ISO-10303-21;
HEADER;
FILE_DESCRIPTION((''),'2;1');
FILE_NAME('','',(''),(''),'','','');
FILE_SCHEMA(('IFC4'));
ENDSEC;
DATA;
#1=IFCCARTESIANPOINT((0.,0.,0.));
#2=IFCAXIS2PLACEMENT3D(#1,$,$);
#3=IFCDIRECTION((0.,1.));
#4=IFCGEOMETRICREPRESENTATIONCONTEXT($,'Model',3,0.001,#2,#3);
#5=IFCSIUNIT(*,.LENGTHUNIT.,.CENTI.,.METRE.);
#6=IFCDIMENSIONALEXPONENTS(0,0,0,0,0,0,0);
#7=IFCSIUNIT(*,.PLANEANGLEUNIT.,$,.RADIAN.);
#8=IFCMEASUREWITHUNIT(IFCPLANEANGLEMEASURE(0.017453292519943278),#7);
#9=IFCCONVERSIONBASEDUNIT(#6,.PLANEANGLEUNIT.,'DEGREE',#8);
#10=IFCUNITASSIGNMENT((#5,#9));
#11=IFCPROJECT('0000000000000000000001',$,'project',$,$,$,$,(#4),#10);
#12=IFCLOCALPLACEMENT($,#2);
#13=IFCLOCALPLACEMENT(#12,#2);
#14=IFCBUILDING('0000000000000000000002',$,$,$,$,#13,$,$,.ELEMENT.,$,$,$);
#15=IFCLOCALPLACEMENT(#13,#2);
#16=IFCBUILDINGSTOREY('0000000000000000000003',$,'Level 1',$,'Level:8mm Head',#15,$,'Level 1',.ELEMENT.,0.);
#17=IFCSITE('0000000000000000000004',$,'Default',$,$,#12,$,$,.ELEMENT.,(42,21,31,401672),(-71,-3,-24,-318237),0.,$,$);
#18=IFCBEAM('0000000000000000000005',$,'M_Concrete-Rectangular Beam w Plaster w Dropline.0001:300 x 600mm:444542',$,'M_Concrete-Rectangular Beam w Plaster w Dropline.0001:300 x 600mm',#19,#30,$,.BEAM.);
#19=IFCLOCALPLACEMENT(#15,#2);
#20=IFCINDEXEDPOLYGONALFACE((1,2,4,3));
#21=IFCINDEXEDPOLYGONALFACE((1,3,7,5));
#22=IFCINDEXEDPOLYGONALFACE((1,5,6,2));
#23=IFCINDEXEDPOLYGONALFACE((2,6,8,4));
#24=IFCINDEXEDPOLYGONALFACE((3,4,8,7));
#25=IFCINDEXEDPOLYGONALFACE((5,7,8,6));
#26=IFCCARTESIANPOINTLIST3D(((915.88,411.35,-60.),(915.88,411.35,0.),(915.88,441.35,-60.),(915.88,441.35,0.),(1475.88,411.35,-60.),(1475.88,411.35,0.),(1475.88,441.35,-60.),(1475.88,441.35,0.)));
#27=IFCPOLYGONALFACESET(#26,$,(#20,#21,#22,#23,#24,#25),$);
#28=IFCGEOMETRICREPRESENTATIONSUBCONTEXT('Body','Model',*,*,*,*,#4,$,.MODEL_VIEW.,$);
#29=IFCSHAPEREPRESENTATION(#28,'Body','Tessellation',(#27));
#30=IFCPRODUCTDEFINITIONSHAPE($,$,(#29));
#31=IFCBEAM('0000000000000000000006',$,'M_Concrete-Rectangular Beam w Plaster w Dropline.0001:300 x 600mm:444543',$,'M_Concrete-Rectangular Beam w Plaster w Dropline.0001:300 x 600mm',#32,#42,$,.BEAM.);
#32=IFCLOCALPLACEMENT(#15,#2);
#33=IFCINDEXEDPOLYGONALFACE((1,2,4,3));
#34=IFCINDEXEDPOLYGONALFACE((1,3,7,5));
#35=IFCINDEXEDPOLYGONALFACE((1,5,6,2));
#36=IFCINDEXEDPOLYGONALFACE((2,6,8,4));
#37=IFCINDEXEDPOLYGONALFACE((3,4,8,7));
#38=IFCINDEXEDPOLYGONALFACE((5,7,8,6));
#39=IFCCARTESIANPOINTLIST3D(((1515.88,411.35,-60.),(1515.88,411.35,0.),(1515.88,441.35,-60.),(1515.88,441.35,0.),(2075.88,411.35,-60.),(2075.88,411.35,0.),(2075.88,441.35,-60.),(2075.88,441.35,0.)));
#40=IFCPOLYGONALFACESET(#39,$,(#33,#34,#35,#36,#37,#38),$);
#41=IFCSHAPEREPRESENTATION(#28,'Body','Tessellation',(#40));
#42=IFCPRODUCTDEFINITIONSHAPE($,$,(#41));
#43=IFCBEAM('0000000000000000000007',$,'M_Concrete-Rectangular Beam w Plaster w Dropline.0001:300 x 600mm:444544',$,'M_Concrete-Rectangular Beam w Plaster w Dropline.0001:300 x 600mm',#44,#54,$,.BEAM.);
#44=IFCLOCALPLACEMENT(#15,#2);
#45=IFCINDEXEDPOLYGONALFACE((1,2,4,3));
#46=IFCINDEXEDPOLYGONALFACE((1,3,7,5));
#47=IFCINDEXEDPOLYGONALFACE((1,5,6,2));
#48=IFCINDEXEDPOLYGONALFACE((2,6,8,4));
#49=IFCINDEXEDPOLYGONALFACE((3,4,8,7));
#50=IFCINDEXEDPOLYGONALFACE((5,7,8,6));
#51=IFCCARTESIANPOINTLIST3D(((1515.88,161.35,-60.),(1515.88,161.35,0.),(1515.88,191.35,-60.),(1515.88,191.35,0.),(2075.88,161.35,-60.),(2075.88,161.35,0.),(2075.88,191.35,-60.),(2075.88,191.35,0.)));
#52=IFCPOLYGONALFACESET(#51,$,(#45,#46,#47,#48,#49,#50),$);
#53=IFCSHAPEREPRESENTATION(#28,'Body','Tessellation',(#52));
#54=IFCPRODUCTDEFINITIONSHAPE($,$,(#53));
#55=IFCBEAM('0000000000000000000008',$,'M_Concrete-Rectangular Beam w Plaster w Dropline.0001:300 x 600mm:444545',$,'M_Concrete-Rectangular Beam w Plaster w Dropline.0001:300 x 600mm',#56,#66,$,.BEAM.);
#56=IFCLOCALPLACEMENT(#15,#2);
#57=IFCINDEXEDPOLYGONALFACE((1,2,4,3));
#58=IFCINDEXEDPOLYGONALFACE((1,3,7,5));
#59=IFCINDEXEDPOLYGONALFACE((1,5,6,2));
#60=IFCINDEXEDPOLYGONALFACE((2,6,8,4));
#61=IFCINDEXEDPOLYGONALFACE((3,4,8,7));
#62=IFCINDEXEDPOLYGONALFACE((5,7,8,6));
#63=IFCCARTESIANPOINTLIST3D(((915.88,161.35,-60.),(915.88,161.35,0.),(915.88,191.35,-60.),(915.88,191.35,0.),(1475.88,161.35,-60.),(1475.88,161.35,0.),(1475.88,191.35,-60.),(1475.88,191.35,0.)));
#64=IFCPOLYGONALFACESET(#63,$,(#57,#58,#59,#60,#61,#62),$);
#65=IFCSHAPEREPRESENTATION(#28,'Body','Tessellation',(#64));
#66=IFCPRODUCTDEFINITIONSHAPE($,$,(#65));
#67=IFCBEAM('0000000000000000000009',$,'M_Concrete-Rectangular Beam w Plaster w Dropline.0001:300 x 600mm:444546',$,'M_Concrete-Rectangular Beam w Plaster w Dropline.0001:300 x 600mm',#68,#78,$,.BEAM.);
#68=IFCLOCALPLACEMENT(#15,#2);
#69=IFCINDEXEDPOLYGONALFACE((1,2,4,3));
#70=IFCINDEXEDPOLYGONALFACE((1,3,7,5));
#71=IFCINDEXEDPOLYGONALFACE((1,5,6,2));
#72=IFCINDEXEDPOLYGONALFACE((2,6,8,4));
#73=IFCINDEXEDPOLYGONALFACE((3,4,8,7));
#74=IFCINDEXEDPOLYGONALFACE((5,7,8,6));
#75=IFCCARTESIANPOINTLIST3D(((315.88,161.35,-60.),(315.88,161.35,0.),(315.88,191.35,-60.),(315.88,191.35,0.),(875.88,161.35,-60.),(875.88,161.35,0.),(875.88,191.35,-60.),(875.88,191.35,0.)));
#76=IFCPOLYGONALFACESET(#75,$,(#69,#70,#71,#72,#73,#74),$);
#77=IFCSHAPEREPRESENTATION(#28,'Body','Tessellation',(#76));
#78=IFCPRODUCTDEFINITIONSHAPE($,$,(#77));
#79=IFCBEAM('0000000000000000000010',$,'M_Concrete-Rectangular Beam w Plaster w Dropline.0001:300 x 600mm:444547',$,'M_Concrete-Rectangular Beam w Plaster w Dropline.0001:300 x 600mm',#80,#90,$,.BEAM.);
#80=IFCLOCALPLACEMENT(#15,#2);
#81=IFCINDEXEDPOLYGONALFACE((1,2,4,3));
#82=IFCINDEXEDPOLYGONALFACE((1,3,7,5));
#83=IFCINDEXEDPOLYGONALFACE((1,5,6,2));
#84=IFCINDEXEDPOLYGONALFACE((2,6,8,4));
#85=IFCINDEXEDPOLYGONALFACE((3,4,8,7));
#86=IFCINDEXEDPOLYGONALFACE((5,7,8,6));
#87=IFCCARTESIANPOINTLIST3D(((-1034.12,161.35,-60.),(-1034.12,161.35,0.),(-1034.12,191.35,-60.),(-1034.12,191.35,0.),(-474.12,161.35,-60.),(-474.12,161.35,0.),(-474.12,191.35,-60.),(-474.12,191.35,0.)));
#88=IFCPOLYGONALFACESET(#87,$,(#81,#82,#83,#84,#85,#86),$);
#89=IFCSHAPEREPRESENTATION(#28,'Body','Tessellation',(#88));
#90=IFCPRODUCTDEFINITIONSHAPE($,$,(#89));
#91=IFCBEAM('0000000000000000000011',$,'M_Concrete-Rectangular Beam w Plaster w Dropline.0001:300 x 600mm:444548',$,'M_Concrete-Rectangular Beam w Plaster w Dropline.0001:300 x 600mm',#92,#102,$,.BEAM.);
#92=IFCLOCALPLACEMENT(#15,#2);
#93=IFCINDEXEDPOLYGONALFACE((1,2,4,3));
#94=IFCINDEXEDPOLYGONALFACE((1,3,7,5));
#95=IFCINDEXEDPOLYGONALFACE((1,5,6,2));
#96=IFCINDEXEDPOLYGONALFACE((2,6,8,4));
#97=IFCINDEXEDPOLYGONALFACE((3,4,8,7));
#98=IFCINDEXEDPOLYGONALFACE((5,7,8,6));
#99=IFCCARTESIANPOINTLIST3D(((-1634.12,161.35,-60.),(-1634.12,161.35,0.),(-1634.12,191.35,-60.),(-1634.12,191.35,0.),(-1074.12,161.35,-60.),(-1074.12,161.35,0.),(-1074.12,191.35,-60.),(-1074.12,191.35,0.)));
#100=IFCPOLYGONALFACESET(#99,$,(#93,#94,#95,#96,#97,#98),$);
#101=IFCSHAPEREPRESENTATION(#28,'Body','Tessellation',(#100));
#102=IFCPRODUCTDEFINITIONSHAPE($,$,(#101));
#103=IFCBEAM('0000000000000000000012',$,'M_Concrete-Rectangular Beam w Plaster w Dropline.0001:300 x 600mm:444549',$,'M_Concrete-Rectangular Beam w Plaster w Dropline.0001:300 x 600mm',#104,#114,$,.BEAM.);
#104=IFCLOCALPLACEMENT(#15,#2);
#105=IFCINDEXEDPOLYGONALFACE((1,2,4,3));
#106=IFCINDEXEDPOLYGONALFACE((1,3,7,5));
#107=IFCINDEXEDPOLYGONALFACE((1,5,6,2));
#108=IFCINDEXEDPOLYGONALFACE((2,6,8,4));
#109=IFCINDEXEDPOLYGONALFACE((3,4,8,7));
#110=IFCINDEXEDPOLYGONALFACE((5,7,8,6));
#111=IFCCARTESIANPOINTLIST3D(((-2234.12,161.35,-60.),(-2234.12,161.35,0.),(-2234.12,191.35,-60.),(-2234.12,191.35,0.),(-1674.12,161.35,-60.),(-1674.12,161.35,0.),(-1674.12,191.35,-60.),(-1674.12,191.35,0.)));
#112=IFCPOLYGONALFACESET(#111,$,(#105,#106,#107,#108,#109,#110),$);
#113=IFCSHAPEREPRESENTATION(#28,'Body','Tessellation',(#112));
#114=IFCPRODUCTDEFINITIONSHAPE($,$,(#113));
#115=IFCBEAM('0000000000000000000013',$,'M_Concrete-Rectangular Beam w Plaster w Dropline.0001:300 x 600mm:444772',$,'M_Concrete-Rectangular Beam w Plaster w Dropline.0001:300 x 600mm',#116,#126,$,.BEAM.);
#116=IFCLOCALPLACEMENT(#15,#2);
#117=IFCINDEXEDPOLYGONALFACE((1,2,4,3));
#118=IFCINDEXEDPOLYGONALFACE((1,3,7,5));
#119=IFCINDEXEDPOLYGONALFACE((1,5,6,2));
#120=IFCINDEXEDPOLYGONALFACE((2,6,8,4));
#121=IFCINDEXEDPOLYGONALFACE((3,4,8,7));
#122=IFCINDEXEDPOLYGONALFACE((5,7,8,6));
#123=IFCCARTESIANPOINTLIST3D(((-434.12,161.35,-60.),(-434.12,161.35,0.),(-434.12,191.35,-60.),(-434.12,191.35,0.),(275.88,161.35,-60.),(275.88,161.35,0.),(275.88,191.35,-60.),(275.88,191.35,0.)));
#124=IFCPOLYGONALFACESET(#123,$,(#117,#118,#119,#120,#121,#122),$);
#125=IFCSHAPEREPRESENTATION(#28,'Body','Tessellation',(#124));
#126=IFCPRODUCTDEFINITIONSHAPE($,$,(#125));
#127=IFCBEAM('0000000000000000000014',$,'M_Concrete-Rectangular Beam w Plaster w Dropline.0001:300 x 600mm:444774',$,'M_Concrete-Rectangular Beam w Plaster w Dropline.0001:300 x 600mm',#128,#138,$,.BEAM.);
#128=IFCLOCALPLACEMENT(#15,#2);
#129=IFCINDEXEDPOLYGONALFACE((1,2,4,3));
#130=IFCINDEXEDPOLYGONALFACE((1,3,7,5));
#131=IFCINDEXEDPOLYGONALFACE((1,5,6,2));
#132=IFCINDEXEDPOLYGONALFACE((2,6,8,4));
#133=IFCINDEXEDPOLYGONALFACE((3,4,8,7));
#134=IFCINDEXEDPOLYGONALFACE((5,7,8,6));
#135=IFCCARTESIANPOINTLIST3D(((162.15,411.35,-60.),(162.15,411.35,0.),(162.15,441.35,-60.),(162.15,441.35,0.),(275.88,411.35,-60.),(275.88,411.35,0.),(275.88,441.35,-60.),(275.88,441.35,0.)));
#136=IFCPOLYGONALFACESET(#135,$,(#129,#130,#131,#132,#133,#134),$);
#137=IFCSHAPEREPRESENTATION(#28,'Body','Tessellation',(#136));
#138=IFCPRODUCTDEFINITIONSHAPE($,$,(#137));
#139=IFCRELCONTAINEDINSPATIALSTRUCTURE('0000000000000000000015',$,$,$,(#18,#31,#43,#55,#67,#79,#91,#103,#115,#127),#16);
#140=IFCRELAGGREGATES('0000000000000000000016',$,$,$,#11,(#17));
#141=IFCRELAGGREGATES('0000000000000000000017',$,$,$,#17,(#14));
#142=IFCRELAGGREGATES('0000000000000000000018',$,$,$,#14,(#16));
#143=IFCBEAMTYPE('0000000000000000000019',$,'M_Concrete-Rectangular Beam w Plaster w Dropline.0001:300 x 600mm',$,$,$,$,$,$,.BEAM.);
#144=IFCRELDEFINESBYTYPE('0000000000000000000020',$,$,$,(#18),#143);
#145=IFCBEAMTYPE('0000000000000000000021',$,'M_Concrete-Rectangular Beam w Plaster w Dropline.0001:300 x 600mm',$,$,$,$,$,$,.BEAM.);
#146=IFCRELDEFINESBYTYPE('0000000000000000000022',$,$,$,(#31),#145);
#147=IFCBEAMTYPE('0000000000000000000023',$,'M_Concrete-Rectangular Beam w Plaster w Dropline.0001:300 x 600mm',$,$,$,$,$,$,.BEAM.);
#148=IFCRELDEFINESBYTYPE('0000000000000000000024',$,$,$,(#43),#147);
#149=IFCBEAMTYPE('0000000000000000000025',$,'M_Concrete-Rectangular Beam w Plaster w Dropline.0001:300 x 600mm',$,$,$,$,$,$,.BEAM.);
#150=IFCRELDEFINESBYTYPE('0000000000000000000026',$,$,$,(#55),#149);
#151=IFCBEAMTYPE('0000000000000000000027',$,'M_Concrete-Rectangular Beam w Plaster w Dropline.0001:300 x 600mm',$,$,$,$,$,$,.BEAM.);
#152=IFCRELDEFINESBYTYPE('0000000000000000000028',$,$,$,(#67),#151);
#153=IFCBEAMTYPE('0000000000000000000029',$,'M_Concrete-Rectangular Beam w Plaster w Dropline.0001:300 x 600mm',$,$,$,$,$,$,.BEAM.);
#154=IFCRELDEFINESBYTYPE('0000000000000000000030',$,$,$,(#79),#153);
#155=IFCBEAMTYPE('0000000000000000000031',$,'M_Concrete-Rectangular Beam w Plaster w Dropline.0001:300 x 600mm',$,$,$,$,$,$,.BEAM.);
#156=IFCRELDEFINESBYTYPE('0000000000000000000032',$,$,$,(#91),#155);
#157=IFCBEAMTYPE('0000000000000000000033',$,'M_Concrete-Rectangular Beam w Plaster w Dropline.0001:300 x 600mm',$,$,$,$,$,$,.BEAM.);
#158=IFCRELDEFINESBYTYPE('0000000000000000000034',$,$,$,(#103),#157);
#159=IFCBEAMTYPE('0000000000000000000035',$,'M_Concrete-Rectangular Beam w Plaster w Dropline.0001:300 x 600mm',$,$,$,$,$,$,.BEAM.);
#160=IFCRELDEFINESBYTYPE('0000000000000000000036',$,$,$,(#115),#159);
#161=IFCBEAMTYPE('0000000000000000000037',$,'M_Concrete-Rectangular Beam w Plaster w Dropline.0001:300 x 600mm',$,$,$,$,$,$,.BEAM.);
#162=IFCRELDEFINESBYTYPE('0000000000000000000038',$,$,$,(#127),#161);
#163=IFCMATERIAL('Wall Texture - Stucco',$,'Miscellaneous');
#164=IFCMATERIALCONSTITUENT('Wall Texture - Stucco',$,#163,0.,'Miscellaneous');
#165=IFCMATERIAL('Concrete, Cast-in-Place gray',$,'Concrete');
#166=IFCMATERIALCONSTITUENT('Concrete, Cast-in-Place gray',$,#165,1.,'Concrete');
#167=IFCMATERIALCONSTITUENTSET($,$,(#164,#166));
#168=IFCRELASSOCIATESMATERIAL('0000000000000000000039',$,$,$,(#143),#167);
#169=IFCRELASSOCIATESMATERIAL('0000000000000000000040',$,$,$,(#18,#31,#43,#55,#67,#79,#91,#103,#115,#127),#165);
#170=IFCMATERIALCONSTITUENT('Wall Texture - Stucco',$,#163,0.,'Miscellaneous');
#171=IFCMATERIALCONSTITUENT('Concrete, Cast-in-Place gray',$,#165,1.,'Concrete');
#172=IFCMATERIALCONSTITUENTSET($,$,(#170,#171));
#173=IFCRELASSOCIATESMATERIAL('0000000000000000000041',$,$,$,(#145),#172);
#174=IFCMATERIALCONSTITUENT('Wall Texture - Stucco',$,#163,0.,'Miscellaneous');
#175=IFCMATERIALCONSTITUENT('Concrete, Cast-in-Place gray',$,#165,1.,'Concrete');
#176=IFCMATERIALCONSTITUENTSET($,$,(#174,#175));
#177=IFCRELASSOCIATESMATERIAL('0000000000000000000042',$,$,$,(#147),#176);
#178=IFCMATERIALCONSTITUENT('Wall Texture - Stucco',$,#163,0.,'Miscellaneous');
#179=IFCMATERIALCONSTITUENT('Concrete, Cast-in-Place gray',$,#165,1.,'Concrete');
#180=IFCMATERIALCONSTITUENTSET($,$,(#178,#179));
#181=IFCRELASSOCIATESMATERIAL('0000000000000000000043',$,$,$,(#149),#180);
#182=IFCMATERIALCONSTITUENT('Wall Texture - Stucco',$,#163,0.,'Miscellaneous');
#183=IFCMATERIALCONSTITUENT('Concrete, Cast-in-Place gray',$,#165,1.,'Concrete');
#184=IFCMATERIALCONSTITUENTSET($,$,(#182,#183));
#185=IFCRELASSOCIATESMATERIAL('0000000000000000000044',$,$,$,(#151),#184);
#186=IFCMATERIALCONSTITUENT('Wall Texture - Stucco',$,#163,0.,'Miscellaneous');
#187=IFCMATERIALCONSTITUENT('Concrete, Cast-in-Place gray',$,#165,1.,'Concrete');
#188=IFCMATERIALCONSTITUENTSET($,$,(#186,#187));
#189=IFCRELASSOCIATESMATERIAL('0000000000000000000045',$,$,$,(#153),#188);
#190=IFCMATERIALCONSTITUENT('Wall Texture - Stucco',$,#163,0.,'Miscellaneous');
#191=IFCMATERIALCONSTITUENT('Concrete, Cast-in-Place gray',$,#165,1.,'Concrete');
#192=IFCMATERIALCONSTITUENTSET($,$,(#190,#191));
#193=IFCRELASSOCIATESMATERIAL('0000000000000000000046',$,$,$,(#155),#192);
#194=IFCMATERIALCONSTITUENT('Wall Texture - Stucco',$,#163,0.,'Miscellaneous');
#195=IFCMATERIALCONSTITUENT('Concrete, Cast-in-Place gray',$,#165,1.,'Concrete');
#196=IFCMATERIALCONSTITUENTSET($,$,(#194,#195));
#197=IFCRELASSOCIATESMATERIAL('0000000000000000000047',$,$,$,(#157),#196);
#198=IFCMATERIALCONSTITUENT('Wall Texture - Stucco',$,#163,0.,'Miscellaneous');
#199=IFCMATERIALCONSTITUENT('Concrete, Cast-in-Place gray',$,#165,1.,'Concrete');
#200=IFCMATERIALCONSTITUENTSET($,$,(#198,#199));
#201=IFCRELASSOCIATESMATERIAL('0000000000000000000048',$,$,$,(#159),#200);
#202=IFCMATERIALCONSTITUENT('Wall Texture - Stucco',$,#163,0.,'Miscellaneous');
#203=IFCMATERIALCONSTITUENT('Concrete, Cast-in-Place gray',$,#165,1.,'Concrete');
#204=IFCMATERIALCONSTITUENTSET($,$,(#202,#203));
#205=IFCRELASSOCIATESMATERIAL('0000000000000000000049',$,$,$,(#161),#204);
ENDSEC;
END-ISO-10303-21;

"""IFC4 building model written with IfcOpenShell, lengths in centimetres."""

from ifc_helpers import new_model, entity, si_unit, converted_unit, direction, frame, origin, place, context, subcontext, project, spatial, indexed_curve, outline, extrude, source, transform, mapped, material, constituent, constituent_set, type_object, type_shapes, element, save


model = new_model("IFC4")

# Units and contexts
model_context = context("Model", 3, precision=0.001, world=origin(), true_north=direction((0.0, 1.0)))
body_context = subcontext(model_context, "Body", "Model", "MODEL_VIEW")
ifc_project = project(units=[si_unit("LENGTHUNIT", "METRE", prefix="CENTI"), converted_unit("PLANEANGLEUNIT", "DEGREE", entity("IfcPlaneAngleMeasure", 0.017453292519943278), si_unit("PLANEANGLEUNIT", "RADIAN"), dimensions=[0, 0, 0, 0, 0, 0, 0])], contexts=[model_context])

# Site, building, storey
site_placement = place(None, origin())
site = spatial("IfcSite", under=ifc_project, at=site_placement, Name="Default", CompositionType="ELEMENT", RefLatitude=(42, 21, 31, 401672), RefLongitude=(-71, -3, -24, -318237), RefElevation=0.0)
building_placement = place(site_placement, origin())
building = spatial("IfcBuilding", under=site, at=building_placement, CompositionType="ELEMENT")
storey_placement = place(building_placement, origin())
storey = spatial("IfcBuildingStorey", under=building, at=storey_placement, Name="Level 1", ObjectType="Level:8mm Head", LongName="Level 1", CompositionType="ELEMENT", Elevation=0.0)

# Beams
ifc_material_1 = material(Name="Concrete, Cast-in-Place gray", Category="Concrete")
ifc_material_2 = material(Name="Wall Texture - Stucco", Category="Miscellaneous")
ifc_constituent_1 = constituent(ifc_material_2, Name="Wall Texture - Stucco", Category="Miscellaneous", fraction=0.0)
ifc_constituent_2 = constituent(ifc_material_1, Name="Concrete, Cast-in-Place gray", Category="Concrete", fraction=1.0)
ifc_constituent_set_1 = constituent_set(constituents=[ifc_constituent_1, ifc_constituent_2])
beam_type_1 = type_object("IfcBeamType", Name="M_Concrete-Rectangular Beam w Plaster w Dropline.0001:300 x 600mm", PredefinedType="BEAM", material=ifc_constituent_set_1)
shared_shape_1 = source(origin(), body_context, "Body", "SweptSolid", [
    extrude(outline(indexed_curve([(-30.0, -15.0), (30.0, -15.0), (30.0, 15.0), (-30.0, 15.0), (-30.0, -15.0)], self_intersect=False)), frame((915.88, 426.35, -30.0), z_axis=(1.0, 0.0, 0.0), x_axis=(0.0, 0.0, -1.0)), (0.0, 0.0, 1.0), 560.0),
])
type_shapes(beam_type_1, [shared_shape_1])
beam_1_placement = place(storey_placement, origin())
element("IfcBeam", 1, at=beam_1_placement, inside=storey, type_object=beam_type_1, material=ifc_material_1, Name="M_Concrete-Rectangular Beam w Plaster w Dropline.0001:300 x 600mm:444542", ObjectType="M_Concrete-Rectangular Beam w Plaster w Dropline.0001:300 x 600mm", PredefinedType="BEAM", context=body_context, shape_type="MappedRepresentation", body=[
    mapped(shared_shape_1, transform((0.0, 0.0, 0.0), scale=1.0)),
])
ifc_constituent_3 = constituent(ifc_material_2, Name="Wall Texture - Stucco", Category="Miscellaneous", fraction=0.0)
ifc_constituent_4 = constituent(ifc_material_1, Name="Concrete, Cast-in-Place gray", Category="Concrete", fraction=1.0)
ifc_constituent_set_2 = constituent_set(constituents=[ifc_constituent_3, ifc_constituent_4])
beam_type_2 = type_object("IfcBeamType", Name="M_Concrete-Rectangular Beam w Plaster w Dropline.0001:300 x 600mm", PredefinedType="BEAM", material=ifc_constituent_set_2)
shared_shape_2 = source(origin(), body_context, "Body", "SweptSolid", [
    extrude(outline(indexed_curve([(-30.0, -15.0), (30.0, -15.0), (30.0, 15.0), (-30.0, 15.0), (-30.0, -15.0)], self_intersect=False)), frame((1515.88, 426.35, -30.0), z_axis=(1.0, 0.0, 0.0), x_axis=(0.0, 0.0, -1.0)), (0.0, 0.0, 1.0), 560.0),
])
type_shapes(beam_type_2, [shared_shape_2])
beam_2_placement = place(storey_placement, origin())
element("IfcBeam", 2, at=beam_2_placement, inside=storey, type_object=beam_type_2, material=ifc_material_1, Name="M_Concrete-Rectangular Beam w Plaster w Dropline.0001:300 x 600mm:444543", ObjectType="M_Concrete-Rectangular Beam w Plaster w Dropline.0001:300 x 600mm", PredefinedType="BEAM", context=body_context, shape_type="MappedRepresentation", body=[
    mapped(shared_shape_2, transform((0.0, 0.0, 0.0), scale=1.0)),
])
ifc_constituent_5 = constituent(ifc_material_2, Name="Wall Texture - Stucco", Category="Miscellaneous", fraction=0.0)
ifc_constituent_6 = constituent(ifc_material_1, Name="Concrete, Cast-in-Place gray", Category="Concrete", fraction=1.0)
ifc_constituent_set_3 = constituent_set(constituents=[ifc_constituent_5, ifc_constituent_6])
beam_type_3 = type_object("IfcBeamType", Name="M_Concrete-Rectangular Beam w Plaster w Dropline.0001:300 x 600mm", PredefinedType="BEAM", material=ifc_constituent_set_3)
shared_shape_3 = source(origin(), body_context, "Body", "SweptSolid", [
    extrude(outline(indexed_curve([(-30.0, -15.0), (30.0, -15.0), (30.0, 15.0), (-30.0, 15.0), (-30.0, -15.0)], self_intersect=False)), frame((2075.88, 176.35, -30.0), z_axis=(-1.0, 0.0, 0.0), x_axis=(0.0, 0.0, -1.0)), (0.0, 0.0, 1.0), 560.0),
])
type_shapes(beam_type_3, [shared_shape_3])
beam_3_placement = place(storey_placement, origin())
element("IfcBeam", 3, at=beam_3_placement, inside=storey, type_object=beam_type_3, material=ifc_material_1, Name="M_Concrete-Rectangular Beam w Plaster w Dropline.0001:300 x 600mm:444544", ObjectType="M_Concrete-Rectangular Beam w Plaster w Dropline.0001:300 x 600mm", PredefinedType="BEAM", context=body_context, shape_type="MappedRepresentation", body=[
    mapped(shared_shape_3, transform((0.0, 0.0, 0.0), scale=1.0)),
])
ifc_constituent_7 = constituent(ifc_material_2, Name="Wall Texture - Stucco", Category="Miscellaneous", fraction=0.0)
ifc_constituent_8 = constituent(ifc_material_1, Name="Concrete, Cast-in-Place gray", Category="Concrete", fraction=1.0)
ifc_constituent_set_4 = constituent_set(constituents=[ifc_constituent_7, ifc_constituent_8])
beam_type_4 = type_object("IfcBeamType", Name="M_Concrete-Rectangular Beam w Plaster w Dropline.0001:300 x 600mm", PredefinedType="BEAM", material=ifc_constituent_set_4)
shared_shape_4 = source(origin(), body_context, "Body", "SweptSolid", [
    extrude(outline(indexed_curve([(-30.0, -15.0), (30.0, -15.0), (30.0, 15.0), (-30.0, 15.0), (-30.0, -15.0)], self_intersect=False)), frame((1475.88, 176.35, -30.0), z_axis=(-1.0, 0.0, 0.0), x_axis=(0.0, 0.0, -1.0)), (0.0, 0.0, 1.0), 560.0),
])
type_shapes(beam_type_4, [shared_shape_4])
beam_4_placement = place(storey_placement, origin())
element("IfcBeam", 4, at=beam_4_placement, inside=storey, type_object=beam_type_4, material=ifc_material_1, Name="M_Concrete-Rectangular Beam w Plaster w Dropline.0001:300 x 600mm:444545", ObjectType="M_Concrete-Rectangular Beam w Plaster w Dropline.0001:300 x 600mm", PredefinedType="BEAM", context=body_context, shape_type="MappedRepresentation", body=[
    mapped(shared_shape_4, transform((0.0, 0.0, 0.0), scale=1.0)),
])
ifc_constituent_9 = constituent(ifc_material_2, Name="Wall Texture - Stucco", Category="Miscellaneous", fraction=0.0)
ifc_constituent_10 = constituent(ifc_material_1, Name="Concrete, Cast-in-Place gray", Category="Concrete", fraction=1.0)
ifc_constituent_set_5 = constituent_set(constituents=[ifc_constituent_9, ifc_constituent_10])
beam_type_5 = type_object("IfcBeamType", Name="M_Concrete-Rectangular Beam w Plaster w Dropline.0001:300 x 600mm", PredefinedType="BEAM", material=ifc_constituent_set_5)
shared_shape_5 = source(origin(), body_context, "Body", "SweptSolid", [
    extrude(outline(indexed_curve([(-30.0, -15.0), (30.0, -15.0), (30.0, 15.0), (-30.0, 15.0), (-30.0, -15.0)], self_intersect=False)), frame((875.88, 176.35, -30.0), z_axis=(-1.0, 0.0, 0.0), x_axis=(0.0, 0.0, -1.0)), (0.0, 0.0, 1.0), 560.0),
])
type_shapes(beam_type_5, [shared_shape_5])
beam_5_placement = place(storey_placement, origin())
element("IfcBeam", 5, at=beam_5_placement, inside=storey, type_object=beam_type_5, material=ifc_material_1, Name="M_Concrete-Rectangular Beam w Plaster w Dropline.0001:300 x 600mm:444546", ObjectType="M_Concrete-Rectangular Beam w Plaster w Dropline.0001:300 x 600mm", PredefinedType="BEAM", context=body_context, shape_type="MappedRepresentation", body=[
    mapped(shared_shape_5, transform((0.0, 0.0, 0.0), scale=1.0)),
])
ifc_constituent_11 = constituent(ifc_material_2, Name="Wall Texture - Stucco", Category="Miscellaneous", fraction=0.0)
ifc_constituent_12 = constituent(ifc_material_1, Name="Concrete, Cast-in-Place gray", Category="Concrete", fraction=1.0)
ifc_constituent_set_6 = constituent_set(constituents=[ifc_constituent_11, ifc_constituent_12])
beam_type_6 = type_object("IfcBeamType", Name="M_Concrete-Rectangular Beam w Plaster w Dropline.0001:300 x 600mm", PredefinedType="BEAM", material=ifc_constituent_set_6)
shared_shape_6 = source(origin(), body_context, "Body", "SweptSolid", [
    extrude(outline(indexed_curve([(-30.0, -15.0), (30.0, -15.0), (30.0, 15.0), (-30.0, 15.0), (-30.0, -15.0)], self_intersect=False)), frame((-474.12, 176.35, -30.0), z_axis=(-1.0, 0.0, 0.0), x_axis=(0.0, 0.0, -1.0)), (0.0, 0.0, 1.0), 560.0),
])
type_shapes(beam_type_6, [shared_shape_6])
beam_6_placement = place(storey_placement, origin())
element("IfcBeam", 6, at=beam_6_placement, inside=storey, type_object=beam_type_6, material=ifc_material_1, Name="M_Concrete-Rectangular Beam w Plaster w Dropline.0001:300 x 600mm:444547", ObjectType="M_Concrete-Rectangular Beam w Plaster w Dropline.0001:300 x 600mm", PredefinedType="BEAM", context=body_context, shape_type="MappedRepresentation", body=[
    mapped(shared_shape_6, transform((0.0, 0.0, 0.0), scale=1.0)),
])
ifc_constituent_13 = constituent(ifc_material_2, Name="Wall Texture - Stucco", Category="Miscellaneous", fraction=0.0)
ifc_constituent_14 = constituent(ifc_material_1, Name="Concrete, Cast-in-Place gray", Category="Concrete", fraction=1.0)
ifc_constituent_set_7 = constituent_set(constituents=[ifc_constituent_13, ifc_constituent_14])
beam_type_7 = type_object("IfcBeamType", Name="M_Concrete-Rectangular Beam w Plaster w Dropline.0001:300 x 600mm", PredefinedType="BEAM", material=ifc_constituent_set_7)
shared_shape_7 = source(origin(), body_context, "Body", "SweptSolid", [
    extrude(outline(indexed_curve([(-30.0, -15.0), (30.0, -15.0), (30.0, 15.0), (-30.0, 15.0), (-30.0, -15.0)], self_intersect=False)), frame((-1074.12, 176.35, -30.0), z_axis=(-1.0, 0.0, 0.0), x_axis=(0.0, 0.0, -1.0)), (0.0, 0.0, 1.0), 560.0),
])
type_shapes(beam_type_7, [shared_shape_7])
beam_7_placement = place(storey_placement, origin())
element("IfcBeam", 7, at=beam_7_placement, inside=storey, type_object=beam_type_7, material=ifc_material_1, Name="M_Concrete-Rectangular Beam w Plaster w Dropline.0001:300 x 600mm:444548", ObjectType="M_Concrete-Rectangular Beam w Plaster w Dropline.0001:300 x 600mm", PredefinedType="BEAM", context=body_context, shape_type="MappedRepresentation", body=[
    mapped(shared_shape_7, transform((0.0, 0.0, 0.0), scale=1.0)),
])
ifc_constituent_15 = constituent(ifc_material_2, Name="Wall Texture - Stucco", Category="Miscellaneous", fraction=0.0)
ifc_constituent_16 = constituent(ifc_material_1, Name="Concrete, Cast-in-Place gray", Category="Concrete", fraction=1.0)
ifc_constituent_set_8 = constituent_set(constituents=[ifc_constituent_15, ifc_constituent_16])
beam_type_8 = type_object("IfcBeamType", Name="M_Concrete-Rectangular Beam w Plaster w Dropline.0001:300 x 600mm", PredefinedType="BEAM", material=ifc_constituent_set_8)
shared_shape_8 = source(origin(), body_context, "Body", "SweptSolid", [
    extrude(outline(indexed_curve([(-30.0, -15.0), (30.0, -15.0), (30.0, 15.0), (-30.0, 15.0), (-30.0, -15.0)], self_intersect=False)), frame((-1674.12, 176.35, -30.0), z_axis=(-1.0, 0.0, 0.0), x_axis=(0.0, 0.0, -1.0)), (0.0, 0.0, 1.0), 560.0),
])
type_shapes(beam_type_8, [shared_shape_8])
beam_8_placement = place(storey_placement, origin())
element("IfcBeam", 8, at=beam_8_placement, inside=storey, type_object=beam_type_8, material=ifc_material_1, Name="M_Concrete-Rectangular Beam w Plaster w Dropline.0001:300 x 600mm:444549", ObjectType="M_Concrete-Rectangular Beam w Plaster w Dropline.0001:300 x 600mm", PredefinedType="BEAM", context=body_context, shape_type="MappedRepresentation", body=[
    mapped(shared_shape_8, transform((0.0, 0.0, 0.0), scale=1.0)),
])
ifc_constituent_17 = constituent(ifc_material_2, Name="Wall Texture - Stucco", Category="Miscellaneous", fraction=0.0)
ifc_constituent_18 = constituent(ifc_material_1, Name="Concrete, Cast-in-Place gray", Category="Concrete", fraction=1.0)
ifc_constituent_set_9 = constituent_set(constituents=[ifc_constituent_17, ifc_constituent_18])
beam_type_9 = type_object("IfcBeamType", Name="M_Concrete-Rectangular Beam w Plaster w Dropline.0001:300 x 600mm", PredefinedType="BEAM", material=ifc_constituent_set_9)
shared_shape_9 = source(origin(), body_context, "Body", "SweptSolid", [
    extrude(outline(indexed_curve([(-30.0, -15.0), (30.0, -15.0), (30.0, 15.0), (-30.0, 15.0), (-30.0, -15.0)], self_intersect=False)), frame((275.88, 176.35, -30.0), z_axis=(-1.0, 0.0, 0.0), x_axis=(0.0, 0.0, -1.0)), (0.0, 0.0, 1.0), 710.0),
])
type_shapes(beam_type_9, [shared_shape_9])
beam_9_placement = place(storey_placement, origin())
element("IfcBeam", 9, at=beam_9_placement, inside=storey, type_object=beam_type_9, material=ifc_material_1, Name="M_Concrete-Rectangular Beam w Plaster w Dropline.0001:300 x 600mm:444772", ObjectType="M_Concrete-Rectangular Beam w Plaster w Dropline.0001:300 x 600mm", PredefinedType="BEAM", context=body_context, shape_type="MappedRepresentation", body=[
    mapped(shared_shape_9, transform((0.0, 0.0, 0.0), scale=1.0)),
])
ifc_constituent_19 = constituent(ifc_material_2, Name="Wall Texture - Stucco", Category="Miscellaneous", fraction=0.0)
ifc_constituent_20 = constituent(ifc_material_1, Name="Concrete, Cast-in-Place gray", Category="Concrete", fraction=1.0)
ifc_constituent_set_10 = constituent_set(constituents=[ifc_constituent_19, ifc_constituent_20])
beam_type_10 = type_object("IfcBeamType", Name="M_Concrete-Rectangular Beam w Plaster w Dropline.0001:300 x 600mm", PredefinedType="BEAM", material=ifc_constituent_set_10)
shared_shape_10 = source(origin(), body_context, "Body", "SweptSolid", [
    extrude(outline(indexed_curve([(-30.0, -15.0), (30.0, -15.0), (30.0, 15.0), (-30.0, 15.0), (-30.0, -15.0)], self_intersect=False)), frame((162.15, 426.35, -30.0), z_axis=(1.0, 0.0, 0.0), x_axis=(0.0, 0.0, -1.0)), (0.0, 0.0, 1.0), 113.73),
])
type_shapes(beam_type_10, [shared_shape_10])
beam_10_placement = place(storey_placement, origin())
element("IfcBeam", 10, at=beam_10_placement, inside=storey, type_object=beam_type_10, material=ifc_material_1, Name="M_Concrete-Rectangular Beam w Plaster w Dropline.0001:300 x 600mm:444774", ObjectType="M_Concrete-Rectangular Beam w Plaster w Dropline.0001:300 x 600mm", PredefinedType="BEAM", context=body_context, shape_type="MappedRepresentation", body=[
    mapped(shared_shape_10, transform((0.0, 0.0, 0.0), scale=1.0)),
])

save(model, "model.ifc")
